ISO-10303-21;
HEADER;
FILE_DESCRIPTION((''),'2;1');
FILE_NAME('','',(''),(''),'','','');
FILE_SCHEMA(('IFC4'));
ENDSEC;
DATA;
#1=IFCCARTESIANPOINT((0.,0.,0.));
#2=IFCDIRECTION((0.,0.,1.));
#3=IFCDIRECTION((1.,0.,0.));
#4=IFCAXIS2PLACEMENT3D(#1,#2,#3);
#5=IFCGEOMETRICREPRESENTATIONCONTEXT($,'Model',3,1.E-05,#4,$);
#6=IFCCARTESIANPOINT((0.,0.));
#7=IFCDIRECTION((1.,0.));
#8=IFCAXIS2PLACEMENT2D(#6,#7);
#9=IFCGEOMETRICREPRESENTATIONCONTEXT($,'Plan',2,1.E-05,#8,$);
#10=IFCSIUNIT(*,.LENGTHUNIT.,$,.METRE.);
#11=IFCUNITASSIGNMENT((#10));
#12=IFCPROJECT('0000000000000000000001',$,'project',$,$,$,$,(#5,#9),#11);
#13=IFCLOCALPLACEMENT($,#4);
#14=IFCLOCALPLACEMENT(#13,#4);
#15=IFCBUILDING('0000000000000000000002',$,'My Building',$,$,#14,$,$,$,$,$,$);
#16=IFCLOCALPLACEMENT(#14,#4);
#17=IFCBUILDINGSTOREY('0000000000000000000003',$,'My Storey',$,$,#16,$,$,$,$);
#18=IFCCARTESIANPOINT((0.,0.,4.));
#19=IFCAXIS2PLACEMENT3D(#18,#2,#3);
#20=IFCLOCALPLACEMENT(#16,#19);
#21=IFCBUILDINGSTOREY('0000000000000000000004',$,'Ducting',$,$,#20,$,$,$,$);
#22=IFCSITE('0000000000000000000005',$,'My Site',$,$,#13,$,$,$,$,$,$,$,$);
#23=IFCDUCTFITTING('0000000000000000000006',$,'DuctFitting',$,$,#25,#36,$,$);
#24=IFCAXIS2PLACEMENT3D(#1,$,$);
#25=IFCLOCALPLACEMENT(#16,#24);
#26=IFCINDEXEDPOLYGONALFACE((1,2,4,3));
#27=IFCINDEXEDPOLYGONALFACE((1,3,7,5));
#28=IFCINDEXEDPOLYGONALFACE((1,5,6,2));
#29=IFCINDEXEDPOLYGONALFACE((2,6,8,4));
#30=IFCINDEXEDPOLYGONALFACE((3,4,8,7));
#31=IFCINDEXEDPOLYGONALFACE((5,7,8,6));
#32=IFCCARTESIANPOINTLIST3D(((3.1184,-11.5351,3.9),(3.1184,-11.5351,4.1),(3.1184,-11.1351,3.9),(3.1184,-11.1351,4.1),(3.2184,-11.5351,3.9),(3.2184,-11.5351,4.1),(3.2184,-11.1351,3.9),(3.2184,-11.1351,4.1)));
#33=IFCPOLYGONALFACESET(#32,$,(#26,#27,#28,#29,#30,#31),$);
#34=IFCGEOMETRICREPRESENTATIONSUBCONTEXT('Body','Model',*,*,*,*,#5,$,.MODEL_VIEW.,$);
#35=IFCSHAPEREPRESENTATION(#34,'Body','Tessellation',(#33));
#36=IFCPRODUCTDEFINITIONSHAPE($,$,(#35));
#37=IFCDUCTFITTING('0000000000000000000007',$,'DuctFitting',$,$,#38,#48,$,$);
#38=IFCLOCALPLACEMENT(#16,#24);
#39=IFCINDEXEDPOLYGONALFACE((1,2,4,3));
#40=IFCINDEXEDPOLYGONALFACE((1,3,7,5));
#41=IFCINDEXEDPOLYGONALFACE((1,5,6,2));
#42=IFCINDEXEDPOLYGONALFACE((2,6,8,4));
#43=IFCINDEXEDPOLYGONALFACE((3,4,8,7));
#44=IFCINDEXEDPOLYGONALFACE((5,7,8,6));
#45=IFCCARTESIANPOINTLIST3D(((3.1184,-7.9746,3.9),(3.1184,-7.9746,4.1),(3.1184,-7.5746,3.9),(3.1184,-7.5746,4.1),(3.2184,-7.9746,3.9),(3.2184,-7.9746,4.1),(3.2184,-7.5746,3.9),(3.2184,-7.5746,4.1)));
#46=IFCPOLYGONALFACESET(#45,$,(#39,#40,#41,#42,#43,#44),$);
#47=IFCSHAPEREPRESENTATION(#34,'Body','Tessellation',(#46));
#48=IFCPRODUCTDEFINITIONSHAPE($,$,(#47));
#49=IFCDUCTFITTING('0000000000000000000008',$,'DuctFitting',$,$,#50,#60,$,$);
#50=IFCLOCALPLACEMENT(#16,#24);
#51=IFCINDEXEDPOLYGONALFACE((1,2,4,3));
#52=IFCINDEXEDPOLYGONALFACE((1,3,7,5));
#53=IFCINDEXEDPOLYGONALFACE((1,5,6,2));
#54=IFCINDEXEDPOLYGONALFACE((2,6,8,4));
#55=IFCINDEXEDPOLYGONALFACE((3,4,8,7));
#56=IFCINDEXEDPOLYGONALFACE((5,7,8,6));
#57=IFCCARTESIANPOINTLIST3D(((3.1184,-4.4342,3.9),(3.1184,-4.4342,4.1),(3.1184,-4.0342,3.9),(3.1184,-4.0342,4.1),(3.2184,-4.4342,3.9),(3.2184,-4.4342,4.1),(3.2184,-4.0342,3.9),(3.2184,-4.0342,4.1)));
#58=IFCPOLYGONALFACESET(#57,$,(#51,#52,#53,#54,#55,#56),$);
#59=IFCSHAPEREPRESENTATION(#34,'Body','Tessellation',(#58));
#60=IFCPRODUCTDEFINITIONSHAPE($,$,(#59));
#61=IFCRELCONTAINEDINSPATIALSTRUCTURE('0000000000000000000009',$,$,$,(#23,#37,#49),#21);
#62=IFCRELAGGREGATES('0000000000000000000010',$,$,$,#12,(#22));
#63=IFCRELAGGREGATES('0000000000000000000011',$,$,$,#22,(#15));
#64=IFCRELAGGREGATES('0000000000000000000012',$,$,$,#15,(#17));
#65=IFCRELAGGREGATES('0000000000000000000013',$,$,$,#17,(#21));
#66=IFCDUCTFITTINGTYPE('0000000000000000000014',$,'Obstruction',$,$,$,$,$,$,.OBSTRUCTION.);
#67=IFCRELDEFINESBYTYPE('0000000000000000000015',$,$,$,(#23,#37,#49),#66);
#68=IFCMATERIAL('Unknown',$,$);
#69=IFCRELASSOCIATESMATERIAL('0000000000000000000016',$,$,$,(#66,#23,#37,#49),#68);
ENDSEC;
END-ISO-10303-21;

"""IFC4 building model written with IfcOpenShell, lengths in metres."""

from ifc_helpers import new_model, si_unit, frame, origin_with_axes, origin_2d_with_axis, place, context, subcontext, project, spatial, rectangle, extrude, material, material_profile, profile_set, profile_usage, type_object, element, save


model = new_model("IFC4")

# Units and contexts
model_context = context("Model", 3, precision=1e-05, world=origin_with_axes())
plan_context = context("Plan", 2, precision=1e-05, world=origin_2d_with_axis())
body_context = subcontext(model_context, "Body", "Model", "MODEL_VIEW")
ifc_project = project(units=[si_unit("LENGTHUNIT", "METRE")], contexts=[model_context, plan_context])

# Site, building, storeys
site_placement = place(None, origin_with_axes())
site = spatial("IfcSite", under=ifc_project, at=site_placement, Name="My Site")
building_placement = place(site_placement, origin_with_axes())
building = spatial("IfcBuilding", under=site, at=building_placement, Name="My Building")
storey_1_placement = place(building_placement, origin_with_axes())
storey_1 = spatial("IfcBuildingStorey", under=building, at=storey_1_placement, Name="My Storey")
storey_2_placement = place(storey_1_placement, frame((0.0, 0.0, 4.0), z_axis=(0.0, 0.0, 1.0), x_axis=(1.0, 0.0, 0.0)))
storey_2 = spatial("IfcBuildingStorey", under=storey_1, at=storey_2_placement, Name="Ducting")

# Shared definitions
ifc_material = material(Name="Unknown")

# Duct fittings
ifc_material_profile_1 = material_profile(ifc_material, rectangle(XDim=0.4, YDim=0.2))
ifc_profile_set_1 = profile_set([ifc_material_profile_1])
duct_fitting_type_1 = type_object("IfcDuctFittingType", Name="Obstruction", PredefinedType="OBSTRUCTION", material=ifc_profile_set_1)
ifc_profile_usage_1 = profile_usage(ifc_profile_set_1, cardinal=5)
duct_fitting_1_placement = place(storey_2_placement, frame((3.2184, -11.3351, 0.0), z_axis=(-1.0, 0.0, 0.0), x_axis=(0.0, -1.0, 0.0)))
element("IfcDuctFitting", 1, at=duct_fitting_1_placement, inside=storey_2, type_object=duct_fitting_type_1, material=ifc_profile_usage_1, Name="DuctFitting", context=body_context, shape_type="SweptSolid", body=[
    extrude(rectangle(XDim=0.4, YDim=0.2), origin_with_axes(), (0.0, 0.0, 1.0), 0.1),
])
ifc_profile_usage_2 = profile_usage(ifc_profile_set_1, cardinal=5)
duct_fitting_2_placement = place(storey_2_placement, frame((3.2184, -7.7746, 0.0), z_axis=(-1.0, 0.0, 0.0), x_axis=(0.0, -1.0, 0.0)))
element("IfcDuctFitting", 2, at=duct_fitting_2_placement, inside=storey_2, type_object=duct_fitting_type_1, material=ifc_profile_usage_2, Name="DuctFitting", context=body_context, shape_type="SweptSolid", body=[
    extrude(rectangle(XDim=0.4, YDim=0.2), origin_with_axes(), (0.0, 0.0, 1.0), 0.1),
])
ifc_profile_usage_3 = profile_usage(ifc_profile_set_1, cardinal=5)
duct_fitting_3_placement = place(storey_2_placement, frame((3.2184, -4.2342, 0.0), z_axis=(-1.0, 0.0, 0.0), x_axis=(0.0, -1.0, 0.0)))
element("IfcDuctFitting", 3, at=duct_fitting_3_placement, inside=storey_2, type_object=duct_fitting_type_1, material=ifc_profile_usage_3, Name="DuctFitting", context=body_context, shape_type="SweptSolid", body=[
    extrude(rectangle(XDim=0.4, YDim=0.2), origin_with_axes(), (0.0, 0.0, 1.0), 0.1),
])

save(model, "model.ifc")
